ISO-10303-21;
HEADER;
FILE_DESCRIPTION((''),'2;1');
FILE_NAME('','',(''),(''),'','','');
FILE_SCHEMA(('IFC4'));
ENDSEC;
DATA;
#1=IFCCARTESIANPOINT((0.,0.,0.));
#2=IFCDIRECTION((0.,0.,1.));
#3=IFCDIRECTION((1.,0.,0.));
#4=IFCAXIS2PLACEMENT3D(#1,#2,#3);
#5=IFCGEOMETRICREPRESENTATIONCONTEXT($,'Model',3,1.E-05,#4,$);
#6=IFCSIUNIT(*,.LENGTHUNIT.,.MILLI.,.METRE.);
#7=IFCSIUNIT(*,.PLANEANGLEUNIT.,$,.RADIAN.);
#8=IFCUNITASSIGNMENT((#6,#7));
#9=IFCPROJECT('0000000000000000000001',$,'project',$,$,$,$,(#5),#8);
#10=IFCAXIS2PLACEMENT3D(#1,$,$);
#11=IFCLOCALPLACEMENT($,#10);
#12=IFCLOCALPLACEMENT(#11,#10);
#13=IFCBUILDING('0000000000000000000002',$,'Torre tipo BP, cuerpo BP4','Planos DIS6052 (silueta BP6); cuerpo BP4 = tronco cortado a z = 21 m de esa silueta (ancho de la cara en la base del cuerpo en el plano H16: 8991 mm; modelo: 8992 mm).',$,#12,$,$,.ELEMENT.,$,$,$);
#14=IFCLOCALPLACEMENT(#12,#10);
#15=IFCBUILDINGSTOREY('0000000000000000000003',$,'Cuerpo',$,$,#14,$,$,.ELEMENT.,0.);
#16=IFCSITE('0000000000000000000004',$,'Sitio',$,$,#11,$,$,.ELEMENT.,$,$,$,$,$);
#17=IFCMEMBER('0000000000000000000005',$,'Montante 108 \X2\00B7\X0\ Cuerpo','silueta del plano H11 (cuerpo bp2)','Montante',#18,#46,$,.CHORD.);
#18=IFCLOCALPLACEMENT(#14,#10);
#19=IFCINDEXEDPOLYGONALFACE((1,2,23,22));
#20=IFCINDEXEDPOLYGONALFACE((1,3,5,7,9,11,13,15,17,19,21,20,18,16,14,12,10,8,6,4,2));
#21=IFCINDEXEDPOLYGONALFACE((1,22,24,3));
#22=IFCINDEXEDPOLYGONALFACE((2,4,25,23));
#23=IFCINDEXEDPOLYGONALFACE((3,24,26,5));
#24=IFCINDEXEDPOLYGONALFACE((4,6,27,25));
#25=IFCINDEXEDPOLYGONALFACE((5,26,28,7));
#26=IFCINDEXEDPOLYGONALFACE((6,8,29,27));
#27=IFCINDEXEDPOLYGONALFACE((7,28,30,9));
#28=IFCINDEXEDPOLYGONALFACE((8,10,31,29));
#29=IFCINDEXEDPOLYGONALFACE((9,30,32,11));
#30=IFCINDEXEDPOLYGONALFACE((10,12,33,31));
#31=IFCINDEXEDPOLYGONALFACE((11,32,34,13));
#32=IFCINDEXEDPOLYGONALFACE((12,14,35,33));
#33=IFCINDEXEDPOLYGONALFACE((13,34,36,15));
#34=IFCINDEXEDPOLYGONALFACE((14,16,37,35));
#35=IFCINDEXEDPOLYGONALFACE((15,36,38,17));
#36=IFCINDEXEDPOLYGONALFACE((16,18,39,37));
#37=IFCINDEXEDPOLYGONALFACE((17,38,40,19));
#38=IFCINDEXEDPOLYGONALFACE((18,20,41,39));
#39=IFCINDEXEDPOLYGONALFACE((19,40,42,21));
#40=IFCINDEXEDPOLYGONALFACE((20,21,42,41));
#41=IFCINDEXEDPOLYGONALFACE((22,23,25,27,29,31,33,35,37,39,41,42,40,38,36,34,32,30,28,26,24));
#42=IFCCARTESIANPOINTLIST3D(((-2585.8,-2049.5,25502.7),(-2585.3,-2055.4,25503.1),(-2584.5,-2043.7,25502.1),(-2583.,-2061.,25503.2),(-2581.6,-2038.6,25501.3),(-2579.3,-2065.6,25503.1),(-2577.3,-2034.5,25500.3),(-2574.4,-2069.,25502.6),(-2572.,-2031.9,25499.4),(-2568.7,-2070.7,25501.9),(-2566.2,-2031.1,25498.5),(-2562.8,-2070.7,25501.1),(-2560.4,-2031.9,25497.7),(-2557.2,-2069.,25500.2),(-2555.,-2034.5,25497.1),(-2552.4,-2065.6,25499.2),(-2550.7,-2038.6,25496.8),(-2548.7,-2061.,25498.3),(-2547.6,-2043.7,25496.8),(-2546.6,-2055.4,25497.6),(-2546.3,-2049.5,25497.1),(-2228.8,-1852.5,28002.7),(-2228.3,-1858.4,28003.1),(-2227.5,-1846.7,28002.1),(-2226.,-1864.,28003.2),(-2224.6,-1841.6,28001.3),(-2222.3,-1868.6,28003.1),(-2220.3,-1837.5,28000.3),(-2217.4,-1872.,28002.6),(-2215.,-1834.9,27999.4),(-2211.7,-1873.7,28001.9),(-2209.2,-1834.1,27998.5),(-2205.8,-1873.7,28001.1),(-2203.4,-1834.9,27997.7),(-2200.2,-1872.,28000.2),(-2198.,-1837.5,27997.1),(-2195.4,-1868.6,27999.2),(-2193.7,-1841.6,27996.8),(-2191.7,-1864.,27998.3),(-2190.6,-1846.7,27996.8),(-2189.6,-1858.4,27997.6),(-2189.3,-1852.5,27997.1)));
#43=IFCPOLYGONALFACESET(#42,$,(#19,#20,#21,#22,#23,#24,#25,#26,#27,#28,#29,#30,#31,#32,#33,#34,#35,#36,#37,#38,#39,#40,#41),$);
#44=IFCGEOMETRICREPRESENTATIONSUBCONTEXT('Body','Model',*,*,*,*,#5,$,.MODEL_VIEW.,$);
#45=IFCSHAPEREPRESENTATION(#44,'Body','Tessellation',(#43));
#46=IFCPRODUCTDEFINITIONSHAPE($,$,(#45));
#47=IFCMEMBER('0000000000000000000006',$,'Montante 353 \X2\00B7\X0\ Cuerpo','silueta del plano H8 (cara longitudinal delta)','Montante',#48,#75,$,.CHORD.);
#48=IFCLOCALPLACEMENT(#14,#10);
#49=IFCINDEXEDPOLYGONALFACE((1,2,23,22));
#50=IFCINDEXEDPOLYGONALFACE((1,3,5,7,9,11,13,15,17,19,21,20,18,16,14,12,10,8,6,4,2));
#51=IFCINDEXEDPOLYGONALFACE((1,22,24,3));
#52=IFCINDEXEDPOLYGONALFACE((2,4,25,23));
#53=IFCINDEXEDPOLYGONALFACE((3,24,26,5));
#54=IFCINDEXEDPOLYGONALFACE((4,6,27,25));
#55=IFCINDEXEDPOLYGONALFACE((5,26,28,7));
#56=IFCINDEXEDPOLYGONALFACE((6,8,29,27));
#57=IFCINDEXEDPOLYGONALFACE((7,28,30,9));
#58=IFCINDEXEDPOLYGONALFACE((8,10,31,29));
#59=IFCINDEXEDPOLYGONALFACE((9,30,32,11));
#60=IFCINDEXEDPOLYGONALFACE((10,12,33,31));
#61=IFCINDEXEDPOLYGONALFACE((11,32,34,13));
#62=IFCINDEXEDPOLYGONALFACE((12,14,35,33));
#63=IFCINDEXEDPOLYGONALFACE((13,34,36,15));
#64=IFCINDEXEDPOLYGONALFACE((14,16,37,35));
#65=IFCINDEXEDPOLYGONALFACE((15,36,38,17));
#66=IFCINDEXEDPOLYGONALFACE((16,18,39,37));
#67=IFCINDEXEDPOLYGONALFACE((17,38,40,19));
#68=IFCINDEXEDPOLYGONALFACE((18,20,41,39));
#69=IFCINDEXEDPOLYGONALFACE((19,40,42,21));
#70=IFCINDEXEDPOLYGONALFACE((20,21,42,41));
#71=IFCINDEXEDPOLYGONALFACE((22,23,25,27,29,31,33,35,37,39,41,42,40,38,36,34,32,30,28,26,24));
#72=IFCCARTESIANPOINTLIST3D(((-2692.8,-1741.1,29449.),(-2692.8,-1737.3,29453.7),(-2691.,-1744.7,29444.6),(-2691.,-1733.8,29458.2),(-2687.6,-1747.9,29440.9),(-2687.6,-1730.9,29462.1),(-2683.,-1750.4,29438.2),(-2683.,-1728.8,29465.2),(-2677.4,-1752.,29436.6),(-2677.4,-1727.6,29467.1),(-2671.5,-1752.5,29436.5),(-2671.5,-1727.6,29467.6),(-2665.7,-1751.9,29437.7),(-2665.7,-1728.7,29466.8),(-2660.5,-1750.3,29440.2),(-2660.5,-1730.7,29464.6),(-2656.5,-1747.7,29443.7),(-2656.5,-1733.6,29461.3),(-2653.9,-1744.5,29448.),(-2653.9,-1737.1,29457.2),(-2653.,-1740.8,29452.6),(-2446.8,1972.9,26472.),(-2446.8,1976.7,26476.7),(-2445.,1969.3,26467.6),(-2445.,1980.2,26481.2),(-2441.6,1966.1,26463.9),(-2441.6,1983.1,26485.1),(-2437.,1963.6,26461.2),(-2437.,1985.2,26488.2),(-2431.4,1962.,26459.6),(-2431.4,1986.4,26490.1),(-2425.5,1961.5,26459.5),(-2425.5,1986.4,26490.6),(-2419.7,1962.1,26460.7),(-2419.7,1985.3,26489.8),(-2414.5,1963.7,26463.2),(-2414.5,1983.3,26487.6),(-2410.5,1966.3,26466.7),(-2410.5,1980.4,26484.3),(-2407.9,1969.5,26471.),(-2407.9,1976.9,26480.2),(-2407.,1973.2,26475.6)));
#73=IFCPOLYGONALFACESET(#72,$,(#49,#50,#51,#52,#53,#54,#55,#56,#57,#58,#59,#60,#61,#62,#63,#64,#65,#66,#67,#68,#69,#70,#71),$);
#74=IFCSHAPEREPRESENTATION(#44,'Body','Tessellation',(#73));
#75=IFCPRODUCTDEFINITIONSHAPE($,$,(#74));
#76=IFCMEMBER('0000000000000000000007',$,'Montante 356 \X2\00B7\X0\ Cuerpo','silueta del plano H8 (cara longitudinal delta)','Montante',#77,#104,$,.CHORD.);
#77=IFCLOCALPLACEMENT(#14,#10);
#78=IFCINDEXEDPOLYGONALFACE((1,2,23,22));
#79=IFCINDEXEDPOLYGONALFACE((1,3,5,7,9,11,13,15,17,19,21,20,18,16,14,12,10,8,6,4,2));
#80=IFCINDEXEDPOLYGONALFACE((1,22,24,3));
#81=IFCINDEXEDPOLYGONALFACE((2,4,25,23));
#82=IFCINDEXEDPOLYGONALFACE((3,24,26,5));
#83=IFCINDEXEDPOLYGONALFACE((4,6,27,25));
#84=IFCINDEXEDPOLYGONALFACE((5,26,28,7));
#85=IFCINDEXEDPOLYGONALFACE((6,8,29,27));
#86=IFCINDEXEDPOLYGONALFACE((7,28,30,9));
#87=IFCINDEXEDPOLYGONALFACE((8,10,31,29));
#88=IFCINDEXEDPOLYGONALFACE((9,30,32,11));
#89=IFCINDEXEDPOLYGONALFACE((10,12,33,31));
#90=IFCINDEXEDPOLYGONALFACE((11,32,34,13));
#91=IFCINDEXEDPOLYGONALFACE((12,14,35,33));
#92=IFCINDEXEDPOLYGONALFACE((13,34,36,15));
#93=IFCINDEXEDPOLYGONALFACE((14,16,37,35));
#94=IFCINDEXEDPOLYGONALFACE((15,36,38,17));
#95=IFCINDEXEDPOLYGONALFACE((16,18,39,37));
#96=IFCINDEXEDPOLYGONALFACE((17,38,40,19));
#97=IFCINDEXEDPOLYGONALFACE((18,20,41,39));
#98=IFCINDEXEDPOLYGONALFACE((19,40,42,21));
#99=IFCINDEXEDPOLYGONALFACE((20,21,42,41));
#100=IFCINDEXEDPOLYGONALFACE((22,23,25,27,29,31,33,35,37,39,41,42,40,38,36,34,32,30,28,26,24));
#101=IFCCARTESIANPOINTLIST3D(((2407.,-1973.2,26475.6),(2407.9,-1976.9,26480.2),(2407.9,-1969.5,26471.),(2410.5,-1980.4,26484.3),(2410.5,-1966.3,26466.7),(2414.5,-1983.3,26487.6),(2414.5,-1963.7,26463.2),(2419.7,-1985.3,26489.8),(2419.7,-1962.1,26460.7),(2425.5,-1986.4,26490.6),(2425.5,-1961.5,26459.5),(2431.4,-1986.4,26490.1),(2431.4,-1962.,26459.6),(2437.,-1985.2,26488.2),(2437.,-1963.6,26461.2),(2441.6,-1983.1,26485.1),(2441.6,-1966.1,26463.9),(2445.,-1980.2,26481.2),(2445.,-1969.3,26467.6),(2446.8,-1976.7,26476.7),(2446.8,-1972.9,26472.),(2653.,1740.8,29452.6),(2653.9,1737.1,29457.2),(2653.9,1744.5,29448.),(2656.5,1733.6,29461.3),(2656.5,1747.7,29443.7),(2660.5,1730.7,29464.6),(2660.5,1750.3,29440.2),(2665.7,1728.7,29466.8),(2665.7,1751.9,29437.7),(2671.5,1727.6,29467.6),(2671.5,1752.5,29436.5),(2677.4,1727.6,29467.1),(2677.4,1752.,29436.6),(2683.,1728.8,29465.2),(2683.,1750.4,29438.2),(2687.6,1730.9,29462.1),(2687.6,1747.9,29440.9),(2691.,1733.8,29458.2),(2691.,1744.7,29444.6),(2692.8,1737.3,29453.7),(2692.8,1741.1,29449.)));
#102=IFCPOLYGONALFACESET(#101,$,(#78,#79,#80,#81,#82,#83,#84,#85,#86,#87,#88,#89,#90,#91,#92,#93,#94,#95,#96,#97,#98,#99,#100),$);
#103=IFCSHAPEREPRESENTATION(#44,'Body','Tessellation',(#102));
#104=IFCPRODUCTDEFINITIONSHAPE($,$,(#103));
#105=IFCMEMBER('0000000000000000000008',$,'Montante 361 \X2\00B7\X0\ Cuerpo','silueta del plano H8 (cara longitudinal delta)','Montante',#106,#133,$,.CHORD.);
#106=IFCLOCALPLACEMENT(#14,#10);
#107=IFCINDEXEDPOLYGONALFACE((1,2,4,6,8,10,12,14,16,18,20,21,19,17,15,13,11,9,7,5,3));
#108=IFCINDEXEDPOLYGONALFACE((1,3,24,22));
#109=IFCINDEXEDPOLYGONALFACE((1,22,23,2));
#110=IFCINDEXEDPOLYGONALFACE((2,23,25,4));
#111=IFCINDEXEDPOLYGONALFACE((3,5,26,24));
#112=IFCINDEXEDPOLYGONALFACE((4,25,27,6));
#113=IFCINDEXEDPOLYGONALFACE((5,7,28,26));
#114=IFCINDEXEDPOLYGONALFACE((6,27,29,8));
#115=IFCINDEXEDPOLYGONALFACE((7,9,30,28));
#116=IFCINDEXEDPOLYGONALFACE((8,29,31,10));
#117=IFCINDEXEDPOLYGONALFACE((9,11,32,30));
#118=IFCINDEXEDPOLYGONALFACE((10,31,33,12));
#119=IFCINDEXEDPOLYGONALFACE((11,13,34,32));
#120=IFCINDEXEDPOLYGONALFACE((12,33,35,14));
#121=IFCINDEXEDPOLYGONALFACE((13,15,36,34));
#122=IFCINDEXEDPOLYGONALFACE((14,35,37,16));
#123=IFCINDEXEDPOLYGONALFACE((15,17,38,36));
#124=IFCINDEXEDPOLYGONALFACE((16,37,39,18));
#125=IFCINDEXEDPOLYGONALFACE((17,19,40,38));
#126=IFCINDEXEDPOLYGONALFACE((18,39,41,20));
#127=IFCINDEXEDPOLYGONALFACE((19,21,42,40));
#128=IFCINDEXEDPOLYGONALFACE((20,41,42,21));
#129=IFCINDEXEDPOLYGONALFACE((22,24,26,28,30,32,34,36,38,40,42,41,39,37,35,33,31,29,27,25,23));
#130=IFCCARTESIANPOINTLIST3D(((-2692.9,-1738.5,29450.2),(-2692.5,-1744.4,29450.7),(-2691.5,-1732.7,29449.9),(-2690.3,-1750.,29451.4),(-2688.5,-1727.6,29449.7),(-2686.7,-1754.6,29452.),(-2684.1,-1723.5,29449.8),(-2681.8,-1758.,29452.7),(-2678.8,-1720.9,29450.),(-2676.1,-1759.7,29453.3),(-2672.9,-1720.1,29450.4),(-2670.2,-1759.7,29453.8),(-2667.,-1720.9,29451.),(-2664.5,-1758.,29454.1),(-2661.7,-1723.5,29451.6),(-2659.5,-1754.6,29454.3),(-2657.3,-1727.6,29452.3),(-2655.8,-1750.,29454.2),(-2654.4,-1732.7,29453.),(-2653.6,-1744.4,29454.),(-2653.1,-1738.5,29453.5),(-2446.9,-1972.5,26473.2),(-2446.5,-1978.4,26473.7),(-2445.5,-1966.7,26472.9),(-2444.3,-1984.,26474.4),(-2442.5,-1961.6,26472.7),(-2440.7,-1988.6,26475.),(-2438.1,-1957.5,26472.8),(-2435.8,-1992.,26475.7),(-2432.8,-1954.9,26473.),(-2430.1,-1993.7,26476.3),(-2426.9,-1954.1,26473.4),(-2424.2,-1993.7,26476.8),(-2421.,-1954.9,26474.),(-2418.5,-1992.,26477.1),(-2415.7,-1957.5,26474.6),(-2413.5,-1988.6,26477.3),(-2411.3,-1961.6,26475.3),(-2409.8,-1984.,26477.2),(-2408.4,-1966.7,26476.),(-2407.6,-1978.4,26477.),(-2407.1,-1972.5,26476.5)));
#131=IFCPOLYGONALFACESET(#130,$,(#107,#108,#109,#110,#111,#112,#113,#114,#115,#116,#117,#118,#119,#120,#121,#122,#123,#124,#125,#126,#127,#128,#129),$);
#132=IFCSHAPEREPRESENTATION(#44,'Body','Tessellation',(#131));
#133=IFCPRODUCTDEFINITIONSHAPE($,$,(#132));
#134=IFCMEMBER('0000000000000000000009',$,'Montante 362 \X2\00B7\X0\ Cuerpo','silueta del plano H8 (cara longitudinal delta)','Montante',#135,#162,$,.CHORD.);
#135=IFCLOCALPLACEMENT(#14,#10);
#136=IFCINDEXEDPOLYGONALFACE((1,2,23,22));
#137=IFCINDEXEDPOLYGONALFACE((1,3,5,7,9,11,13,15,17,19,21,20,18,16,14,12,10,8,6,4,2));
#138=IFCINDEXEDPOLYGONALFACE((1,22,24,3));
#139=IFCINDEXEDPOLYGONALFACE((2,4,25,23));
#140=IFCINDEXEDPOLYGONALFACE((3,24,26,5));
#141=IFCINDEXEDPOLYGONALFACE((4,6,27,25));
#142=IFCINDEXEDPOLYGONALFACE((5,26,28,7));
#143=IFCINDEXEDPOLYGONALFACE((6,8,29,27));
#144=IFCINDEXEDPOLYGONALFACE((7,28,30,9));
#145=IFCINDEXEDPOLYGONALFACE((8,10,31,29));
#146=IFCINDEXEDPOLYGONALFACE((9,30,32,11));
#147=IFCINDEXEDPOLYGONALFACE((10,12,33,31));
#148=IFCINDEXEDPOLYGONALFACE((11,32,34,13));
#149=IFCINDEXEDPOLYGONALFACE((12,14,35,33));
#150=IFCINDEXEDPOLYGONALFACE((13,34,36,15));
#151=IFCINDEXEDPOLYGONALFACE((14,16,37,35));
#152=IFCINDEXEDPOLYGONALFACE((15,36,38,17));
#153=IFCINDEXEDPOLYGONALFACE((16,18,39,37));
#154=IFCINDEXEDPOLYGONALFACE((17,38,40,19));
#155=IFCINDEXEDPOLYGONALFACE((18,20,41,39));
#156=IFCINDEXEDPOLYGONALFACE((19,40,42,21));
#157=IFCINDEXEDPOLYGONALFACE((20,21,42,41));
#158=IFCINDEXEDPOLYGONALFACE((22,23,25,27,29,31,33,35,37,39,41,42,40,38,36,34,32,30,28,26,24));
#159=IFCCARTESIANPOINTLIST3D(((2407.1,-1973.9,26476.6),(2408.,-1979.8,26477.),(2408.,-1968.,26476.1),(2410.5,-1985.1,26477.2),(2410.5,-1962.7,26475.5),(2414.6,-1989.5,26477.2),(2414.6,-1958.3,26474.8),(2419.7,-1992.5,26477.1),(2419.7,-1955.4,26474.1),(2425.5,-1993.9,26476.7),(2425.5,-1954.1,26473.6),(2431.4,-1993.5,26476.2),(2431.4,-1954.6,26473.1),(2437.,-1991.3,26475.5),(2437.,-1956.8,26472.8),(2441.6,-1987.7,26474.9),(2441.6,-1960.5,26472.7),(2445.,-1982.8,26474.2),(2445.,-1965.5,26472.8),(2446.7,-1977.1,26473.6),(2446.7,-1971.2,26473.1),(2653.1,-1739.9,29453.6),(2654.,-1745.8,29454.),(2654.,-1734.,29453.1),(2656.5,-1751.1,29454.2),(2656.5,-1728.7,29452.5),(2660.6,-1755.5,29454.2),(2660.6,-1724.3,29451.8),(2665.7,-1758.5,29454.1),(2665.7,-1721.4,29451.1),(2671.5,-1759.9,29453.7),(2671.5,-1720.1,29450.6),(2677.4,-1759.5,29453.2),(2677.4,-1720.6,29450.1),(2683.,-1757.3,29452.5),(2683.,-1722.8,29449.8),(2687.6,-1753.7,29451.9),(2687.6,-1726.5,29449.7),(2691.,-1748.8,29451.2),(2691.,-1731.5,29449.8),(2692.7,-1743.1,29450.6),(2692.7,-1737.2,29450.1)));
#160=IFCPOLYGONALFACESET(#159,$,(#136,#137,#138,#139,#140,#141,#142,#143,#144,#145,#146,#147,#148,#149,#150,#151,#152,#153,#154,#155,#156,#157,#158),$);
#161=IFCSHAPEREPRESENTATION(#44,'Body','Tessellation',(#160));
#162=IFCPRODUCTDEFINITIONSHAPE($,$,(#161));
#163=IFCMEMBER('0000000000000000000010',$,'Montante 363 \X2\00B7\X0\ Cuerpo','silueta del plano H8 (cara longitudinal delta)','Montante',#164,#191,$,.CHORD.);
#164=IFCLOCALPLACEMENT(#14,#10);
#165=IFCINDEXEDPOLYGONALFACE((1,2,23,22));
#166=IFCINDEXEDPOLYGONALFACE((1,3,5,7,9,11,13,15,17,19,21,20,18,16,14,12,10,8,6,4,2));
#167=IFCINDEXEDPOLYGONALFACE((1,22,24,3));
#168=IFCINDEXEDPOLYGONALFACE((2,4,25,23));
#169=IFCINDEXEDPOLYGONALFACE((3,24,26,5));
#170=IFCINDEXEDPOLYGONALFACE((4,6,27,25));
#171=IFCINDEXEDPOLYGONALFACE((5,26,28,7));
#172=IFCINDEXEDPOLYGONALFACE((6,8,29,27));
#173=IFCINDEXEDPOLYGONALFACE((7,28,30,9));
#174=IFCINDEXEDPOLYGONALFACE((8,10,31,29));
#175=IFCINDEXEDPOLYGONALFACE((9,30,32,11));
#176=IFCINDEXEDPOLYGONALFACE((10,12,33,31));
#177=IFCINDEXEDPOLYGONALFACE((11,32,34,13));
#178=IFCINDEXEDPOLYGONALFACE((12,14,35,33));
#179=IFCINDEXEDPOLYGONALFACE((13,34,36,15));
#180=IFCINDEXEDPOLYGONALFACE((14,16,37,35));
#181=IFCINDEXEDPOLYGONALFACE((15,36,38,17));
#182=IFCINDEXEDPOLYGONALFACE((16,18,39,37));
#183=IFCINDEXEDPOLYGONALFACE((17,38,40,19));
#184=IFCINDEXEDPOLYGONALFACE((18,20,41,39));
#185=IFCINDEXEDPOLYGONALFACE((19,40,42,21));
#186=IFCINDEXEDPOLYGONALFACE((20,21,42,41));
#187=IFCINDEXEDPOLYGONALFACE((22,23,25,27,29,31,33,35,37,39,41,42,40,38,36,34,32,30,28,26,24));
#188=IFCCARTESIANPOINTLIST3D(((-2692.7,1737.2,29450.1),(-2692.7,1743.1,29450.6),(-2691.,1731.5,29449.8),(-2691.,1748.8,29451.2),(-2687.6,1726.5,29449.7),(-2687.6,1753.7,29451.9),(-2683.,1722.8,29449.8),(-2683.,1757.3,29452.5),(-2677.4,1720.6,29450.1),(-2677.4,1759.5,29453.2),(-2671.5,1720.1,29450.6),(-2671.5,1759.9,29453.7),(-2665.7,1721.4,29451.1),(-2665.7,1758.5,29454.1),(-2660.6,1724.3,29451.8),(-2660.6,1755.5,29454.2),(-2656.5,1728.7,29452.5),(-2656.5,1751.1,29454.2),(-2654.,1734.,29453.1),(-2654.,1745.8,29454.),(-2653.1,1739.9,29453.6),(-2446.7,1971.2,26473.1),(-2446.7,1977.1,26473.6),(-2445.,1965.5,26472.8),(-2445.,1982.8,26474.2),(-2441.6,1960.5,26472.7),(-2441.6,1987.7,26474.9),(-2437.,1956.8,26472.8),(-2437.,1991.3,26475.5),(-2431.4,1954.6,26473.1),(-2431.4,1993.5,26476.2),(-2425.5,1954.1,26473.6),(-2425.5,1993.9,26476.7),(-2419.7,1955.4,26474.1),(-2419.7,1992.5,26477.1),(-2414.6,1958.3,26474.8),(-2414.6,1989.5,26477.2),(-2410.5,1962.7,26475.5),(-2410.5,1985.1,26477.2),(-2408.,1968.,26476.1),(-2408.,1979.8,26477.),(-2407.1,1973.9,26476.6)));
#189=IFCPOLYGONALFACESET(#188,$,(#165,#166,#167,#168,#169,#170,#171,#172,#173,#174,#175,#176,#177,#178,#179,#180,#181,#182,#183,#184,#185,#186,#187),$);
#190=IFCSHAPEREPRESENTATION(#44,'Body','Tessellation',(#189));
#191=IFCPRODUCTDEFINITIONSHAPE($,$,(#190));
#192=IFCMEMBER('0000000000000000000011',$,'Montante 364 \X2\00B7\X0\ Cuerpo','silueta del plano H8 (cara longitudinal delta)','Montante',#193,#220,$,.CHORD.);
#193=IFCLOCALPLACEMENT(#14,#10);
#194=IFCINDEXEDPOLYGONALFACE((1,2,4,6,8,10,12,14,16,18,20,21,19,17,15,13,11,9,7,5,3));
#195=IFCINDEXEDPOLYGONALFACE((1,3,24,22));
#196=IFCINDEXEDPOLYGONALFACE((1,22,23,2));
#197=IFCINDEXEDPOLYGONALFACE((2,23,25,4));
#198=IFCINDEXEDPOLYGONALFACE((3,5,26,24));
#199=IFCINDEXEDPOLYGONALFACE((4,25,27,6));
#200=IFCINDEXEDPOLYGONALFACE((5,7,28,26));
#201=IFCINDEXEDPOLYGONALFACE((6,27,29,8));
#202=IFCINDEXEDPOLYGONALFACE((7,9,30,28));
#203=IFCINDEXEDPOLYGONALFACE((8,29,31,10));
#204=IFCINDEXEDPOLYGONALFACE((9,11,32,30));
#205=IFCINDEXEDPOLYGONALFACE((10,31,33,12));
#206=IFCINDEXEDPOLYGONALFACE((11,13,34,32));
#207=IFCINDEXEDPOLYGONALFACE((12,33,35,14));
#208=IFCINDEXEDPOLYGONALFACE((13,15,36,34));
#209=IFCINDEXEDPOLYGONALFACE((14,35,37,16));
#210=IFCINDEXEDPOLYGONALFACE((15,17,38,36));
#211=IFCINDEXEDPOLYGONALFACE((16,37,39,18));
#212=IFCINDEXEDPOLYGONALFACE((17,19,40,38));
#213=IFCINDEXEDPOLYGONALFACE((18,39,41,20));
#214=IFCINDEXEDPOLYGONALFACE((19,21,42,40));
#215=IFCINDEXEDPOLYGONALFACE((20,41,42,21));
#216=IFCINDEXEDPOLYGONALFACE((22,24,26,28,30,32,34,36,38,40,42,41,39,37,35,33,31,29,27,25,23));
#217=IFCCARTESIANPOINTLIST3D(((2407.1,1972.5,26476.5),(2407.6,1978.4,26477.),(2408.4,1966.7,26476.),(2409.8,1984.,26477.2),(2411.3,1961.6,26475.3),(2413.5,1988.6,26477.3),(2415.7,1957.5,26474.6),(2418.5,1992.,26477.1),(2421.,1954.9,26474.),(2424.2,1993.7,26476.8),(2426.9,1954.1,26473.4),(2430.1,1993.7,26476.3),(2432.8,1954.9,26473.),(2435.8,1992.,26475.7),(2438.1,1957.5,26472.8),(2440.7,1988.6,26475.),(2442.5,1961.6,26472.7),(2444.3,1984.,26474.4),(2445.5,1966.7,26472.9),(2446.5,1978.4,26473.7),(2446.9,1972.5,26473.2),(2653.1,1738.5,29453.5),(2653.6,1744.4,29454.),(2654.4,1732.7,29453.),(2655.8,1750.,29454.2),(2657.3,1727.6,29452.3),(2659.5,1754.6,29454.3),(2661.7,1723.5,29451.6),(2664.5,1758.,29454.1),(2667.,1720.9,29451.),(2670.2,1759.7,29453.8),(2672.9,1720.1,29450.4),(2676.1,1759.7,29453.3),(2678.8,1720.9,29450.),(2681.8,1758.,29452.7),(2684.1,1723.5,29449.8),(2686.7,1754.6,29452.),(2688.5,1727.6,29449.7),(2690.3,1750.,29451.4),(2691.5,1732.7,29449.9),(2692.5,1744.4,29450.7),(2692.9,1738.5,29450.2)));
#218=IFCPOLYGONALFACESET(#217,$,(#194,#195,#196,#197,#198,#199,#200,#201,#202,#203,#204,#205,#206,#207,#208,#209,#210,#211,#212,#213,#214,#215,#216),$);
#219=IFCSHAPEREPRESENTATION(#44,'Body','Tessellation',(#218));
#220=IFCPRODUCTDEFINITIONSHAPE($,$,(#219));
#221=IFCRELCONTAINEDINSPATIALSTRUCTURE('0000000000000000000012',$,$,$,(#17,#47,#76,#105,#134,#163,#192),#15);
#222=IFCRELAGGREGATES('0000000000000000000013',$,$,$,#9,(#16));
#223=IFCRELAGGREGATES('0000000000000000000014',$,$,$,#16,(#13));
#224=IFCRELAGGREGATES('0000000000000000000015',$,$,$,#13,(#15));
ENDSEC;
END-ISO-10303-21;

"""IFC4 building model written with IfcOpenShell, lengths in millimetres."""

from ifc_helpers import new_model, si_unit, frame, origin, origin_with_axes, place, context, subcontext, project, spatial, circle, extrude, element, save


model = new_model("IFC4")

# Units and contexts
model_context = context("Model", 3, precision=1e-05, world=origin_with_axes())
body_context = subcontext(model_context, "Body", "Model", "MODEL_VIEW")
ifc_project = project(units=[si_unit("LENGTHUNIT", "METRE", prefix="MILLI"), si_unit("PLANEANGLEUNIT", "RADIAN")], contexts=[model_context])

# Site, building, storey
site_placement = place(None, origin())
site = spatial("IfcSite", under=ifc_project, at=site_placement, Name="Sitio", CompositionType="ELEMENT")
building_placement = place(site_placement, origin())
building = spatial("IfcBuilding", under=site, at=building_placement, Name="Torre tipo BP, cuerpo BP4", Description="Planos DIS6052 (silueta BP6); cuerpo BP4 = tronco cortado a z = 21 m de esa silueta (ancho de la cara en la base del cuerpo en el plano H16: 8991 mm; modelo: 8992 mm).", CompositionType="ELEMENT")
storey_placement = place(building_placement, origin())
storey = spatial("IfcBuildingStorey", under=building, at=storey_placement, Name="Cuerpo", CompositionType="ELEMENT", Elevation=0.0)

# Members
for number, where, z_axis, x_axis, name in (
    (1, (-2209.0, -1854.0, 28000.0), (-0.140938, -0.077772, -0.986959), (-0.010994, 0.996971, -0.076991), "Montante 108 · Cuerpo"),
):
    element("IfcMember", number, at=place(storey_placement, frame(where, z_axis=z_axis, x_axis=x_axis)), inside=storey, Name=name, Description="silueta del plano H11 (cuerpo bp2)", ObjectType="Montante", PredefinedType="CHORD", context=body_context, shape_type="SweptSolid", body=[
        extrude(circle(Radius=20.0), None, (0.0, 0.0, 1.0), 2533.0),
    ])
for number, where, z_axis, x_axis, name in (
    (2, (-2673.0, -1740.0, 29452.0), (0.051613, 0.779234, -0.624604), (0.998667, -0.040272, 0.032281), "Montante 353 · Cuerpo"),
    (3, (2673.0, 1740.0, 29452.0), (-0.051613, -0.779234, -0.624604), (-0.998667, 0.040272, 0.032281), "Montante 356 · Cuerpo"),
):
    element("IfcMember", number, at=place(storey_placement, frame(where, z_axis=z_axis, x_axis=x_axis)), inside=storey, Name=name, Description="silueta del plano H8 (cara longitudinal delta)", ObjectType="Montante", PredefinedType="CHORD", context=body_context, shape_type="SweptSolid", body=[
        extrude(circle(Radius=20.0), None, (0.0, 0.0, 1.0), 4766.2),
    ])
for number, where, z_axis, x_axis, name in (
    (4, (-2673.0, -1740.0, 29452.0), (0.082101, -0.078096, -0.993559), (0.006431, 0.996946, -0.077831), "Montante 361 · Cuerpo"),
    (5, (2673.0, -1740.0, 29452.0), (-0.082101, -0.078096, -0.993559), (-0.996624, 0.006434, 0.081849), "Montante 362 · Cuerpo"),
    (6, (-2673.0, 1740.0, 29452.0), (0.082101, 0.078096, -0.993559), (0.996624, -0.006434, 0.081849), "Montante 363 · Cuerpo"),
    (7, (2673.0, 1740.0, 29452.0), (-0.082101, 0.078096, -0.993559), (-0.006431, -0.996946, -0.077831), "Montante 364 · Cuerpo"),
):
    element("IfcMember", number, at=place(storey_placement, frame(where, z_axis=z_axis, x_axis=x_axis)), inside=storey, Name=name, Description="silueta del plano H8 (cara longitudinal delta)", ObjectType="Montante", PredefinedType="CHORD", context=body_context, shape_type="SweptSolid", body=[
        extrude(circle(Radius=20.0), None, (0.0, 0.0, 1.0), 2996.3),
    ])

save(model, "model.ifc")
